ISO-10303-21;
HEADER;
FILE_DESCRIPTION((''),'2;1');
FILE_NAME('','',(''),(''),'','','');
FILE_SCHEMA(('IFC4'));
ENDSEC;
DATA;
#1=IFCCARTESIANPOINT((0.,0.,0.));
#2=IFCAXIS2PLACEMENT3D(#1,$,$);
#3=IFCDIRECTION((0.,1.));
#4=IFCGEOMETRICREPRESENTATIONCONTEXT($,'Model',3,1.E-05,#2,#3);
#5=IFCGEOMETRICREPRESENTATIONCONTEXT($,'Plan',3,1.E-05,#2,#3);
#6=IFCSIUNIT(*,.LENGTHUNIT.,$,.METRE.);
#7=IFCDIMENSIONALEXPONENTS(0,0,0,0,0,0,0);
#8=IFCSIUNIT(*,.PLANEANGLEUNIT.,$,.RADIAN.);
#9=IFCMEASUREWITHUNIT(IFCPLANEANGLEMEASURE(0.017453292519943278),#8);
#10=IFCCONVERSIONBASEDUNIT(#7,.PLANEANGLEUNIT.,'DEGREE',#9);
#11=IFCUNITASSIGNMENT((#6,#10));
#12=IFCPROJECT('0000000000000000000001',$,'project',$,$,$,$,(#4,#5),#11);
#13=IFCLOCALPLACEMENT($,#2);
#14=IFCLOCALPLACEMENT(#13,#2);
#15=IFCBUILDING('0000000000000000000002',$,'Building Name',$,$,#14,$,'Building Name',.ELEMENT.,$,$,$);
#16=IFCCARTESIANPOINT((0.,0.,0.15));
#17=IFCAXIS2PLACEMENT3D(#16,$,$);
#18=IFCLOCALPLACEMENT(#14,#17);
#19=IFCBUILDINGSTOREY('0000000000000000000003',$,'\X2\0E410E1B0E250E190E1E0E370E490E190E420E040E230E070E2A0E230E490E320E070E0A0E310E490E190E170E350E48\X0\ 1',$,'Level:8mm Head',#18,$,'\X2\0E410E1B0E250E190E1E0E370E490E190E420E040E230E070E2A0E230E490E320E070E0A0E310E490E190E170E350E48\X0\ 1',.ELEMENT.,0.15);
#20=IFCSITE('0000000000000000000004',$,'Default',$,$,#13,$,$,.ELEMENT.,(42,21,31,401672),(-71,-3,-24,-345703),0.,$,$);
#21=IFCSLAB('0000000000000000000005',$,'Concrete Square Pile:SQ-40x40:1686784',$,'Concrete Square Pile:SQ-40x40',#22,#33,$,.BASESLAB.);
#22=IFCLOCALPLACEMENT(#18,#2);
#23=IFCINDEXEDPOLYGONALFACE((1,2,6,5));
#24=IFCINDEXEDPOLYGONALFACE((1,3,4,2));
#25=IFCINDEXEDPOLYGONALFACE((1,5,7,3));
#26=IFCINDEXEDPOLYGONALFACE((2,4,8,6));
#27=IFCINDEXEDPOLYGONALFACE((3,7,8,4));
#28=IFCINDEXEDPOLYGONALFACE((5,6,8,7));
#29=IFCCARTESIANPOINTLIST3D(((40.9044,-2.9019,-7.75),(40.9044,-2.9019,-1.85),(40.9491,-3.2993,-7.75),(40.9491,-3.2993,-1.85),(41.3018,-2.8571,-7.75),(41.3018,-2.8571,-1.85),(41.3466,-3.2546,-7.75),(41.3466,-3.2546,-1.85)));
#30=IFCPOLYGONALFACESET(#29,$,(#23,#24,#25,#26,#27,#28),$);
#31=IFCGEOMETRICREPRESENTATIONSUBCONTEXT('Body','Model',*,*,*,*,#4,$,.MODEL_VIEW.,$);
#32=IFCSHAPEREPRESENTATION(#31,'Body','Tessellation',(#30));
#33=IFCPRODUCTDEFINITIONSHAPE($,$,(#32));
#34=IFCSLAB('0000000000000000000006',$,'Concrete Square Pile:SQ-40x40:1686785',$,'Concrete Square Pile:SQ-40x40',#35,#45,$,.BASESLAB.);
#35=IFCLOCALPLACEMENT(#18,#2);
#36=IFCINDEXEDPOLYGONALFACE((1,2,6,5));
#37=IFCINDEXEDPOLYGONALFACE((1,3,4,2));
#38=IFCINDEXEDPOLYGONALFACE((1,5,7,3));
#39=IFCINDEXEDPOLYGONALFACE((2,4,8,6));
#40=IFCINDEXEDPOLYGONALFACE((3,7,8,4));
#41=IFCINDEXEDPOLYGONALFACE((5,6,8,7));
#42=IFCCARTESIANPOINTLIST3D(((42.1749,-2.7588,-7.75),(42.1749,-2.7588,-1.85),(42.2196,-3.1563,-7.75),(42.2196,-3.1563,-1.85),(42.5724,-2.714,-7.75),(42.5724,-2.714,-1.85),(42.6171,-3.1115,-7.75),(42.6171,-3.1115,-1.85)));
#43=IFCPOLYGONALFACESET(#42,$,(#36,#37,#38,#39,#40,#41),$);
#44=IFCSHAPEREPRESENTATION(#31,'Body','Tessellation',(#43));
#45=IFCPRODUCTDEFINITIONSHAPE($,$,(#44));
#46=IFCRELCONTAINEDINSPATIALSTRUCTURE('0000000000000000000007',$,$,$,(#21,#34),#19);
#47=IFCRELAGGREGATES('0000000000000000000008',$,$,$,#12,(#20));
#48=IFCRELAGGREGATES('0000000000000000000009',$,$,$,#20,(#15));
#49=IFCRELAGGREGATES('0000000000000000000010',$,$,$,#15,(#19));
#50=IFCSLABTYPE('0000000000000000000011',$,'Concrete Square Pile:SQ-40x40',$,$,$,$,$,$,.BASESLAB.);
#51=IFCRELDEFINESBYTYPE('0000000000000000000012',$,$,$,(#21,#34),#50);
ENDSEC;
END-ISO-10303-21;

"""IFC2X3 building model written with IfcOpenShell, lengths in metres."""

from ifc_helpers import new_model, entity, si_unit, converted_unit, direction, frame, frame_2d, origin, place, context, subcontext, project, spatial, rectangle, extrude, type_object, element, save


model = new_model("IFC2X3")

# Units and contexts
model_context = context("Model", 3, precision=1e-05, world=origin(), true_north=direction((0.0, 1.0)))
plan_context = context("Plan", 3, precision=1e-05, world=origin(), true_north=direction((0.0, 1.0)))
body_context = subcontext(model_context, "Body", "Model", "MODEL_VIEW")
ifc_project = project(units=[si_unit("LENGTHUNIT", "METRE"), converted_unit("PLANEANGLEUNIT", "DEGREE", entity("IfcPlaneAngleMeasure", 0.017453292519943278), si_unit("PLANEANGLEUNIT", "RADIAN"), dimensions=[0, 0, 0, 0, 0, 0, 0])], contexts=[model_context, plan_context])

# Site, building, storey
site_placement = place(None, origin())
site = spatial("IfcSite", under=ifc_project, at=site_placement, Name="Default", CompositionType="ELEMENT", RefLatitude=(42, 21, 31, 401672), RefLongitude=(-71, -3, -24, -345703), RefElevation=0.0)
building_placement = place(site_placement, origin())
building = spatial("IfcBuilding", under=site, at=building_placement, Name="Building Name", LongName="Building Name", CompositionType="ELEMENT")
storey_placement = place(building_placement, frame((0.0, 0.0, 0.15)))
storey = spatial("IfcBuildingStorey", under=building, at=storey_placement, Name="แปลนพื้นโครงสร้างชั้นที่ 1", ObjectType="Level:8mm Head", LongName="แปลนพื้นโครงสร้างชั้นที่ 1", CompositionType="ELEMENT", Elevation=0.15)

# Slabs
slab_type_1 = type_object("IfcSlabType", Name="Concrete Square Pile:SQ-40x40", PredefinedType="BASESLAB")
slab_1_placement = place(storey_placement, origin())
element("IfcSlab", 1, at=slab_1_placement, inside=storey, type_object=slab_type_1, Name="Concrete Square Pile:SQ-40x40:1686784", ObjectType="Concrete Square Pile:SQ-40x40", PredefinedType="BASESLAB", context=body_context, shape_type="SweptSolid", body=[
    extrude(rectangle(XDim=0.4, YDim=0.4, at=frame_2d((0.0, 0.0), x_axis=(1.0, 0.0))), frame((41.1255, -3.0782, -7.75), z_axis=(0.0, 0.0, 1.0), x_axis=(-0.993719, -0.111904, 0.0)), (0.0, 0.0, 1.0), 5.9),
])
slab_2_placement = place(storey_placement, origin())
element("IfcSlab", 2, at=slab_2_placement, inside=storey, type_object=slab_type_1, Name="Concrete Square Pile:SQ-40x40:1686785", ObjectType="Concrete Square Pile:SQ-40x40", PredefinedType="BASESLAB", context=body_context, shape_type="SweptSolid", body=[
    extrude(rectangle(XDim=0.4, YDim=0.4, at=frame_2d((0.0, 0.0), x_axis=(1.0, 0.0))), frame((42.396, -2.9351, -7.75), z_axis=(0.0, 0.0, 1.0), x_axis=(-0.993719, -0.111904, 0.0)), (0.0, 0.0, 1.0), 5.9),
])

save(model, "model.ifc")
